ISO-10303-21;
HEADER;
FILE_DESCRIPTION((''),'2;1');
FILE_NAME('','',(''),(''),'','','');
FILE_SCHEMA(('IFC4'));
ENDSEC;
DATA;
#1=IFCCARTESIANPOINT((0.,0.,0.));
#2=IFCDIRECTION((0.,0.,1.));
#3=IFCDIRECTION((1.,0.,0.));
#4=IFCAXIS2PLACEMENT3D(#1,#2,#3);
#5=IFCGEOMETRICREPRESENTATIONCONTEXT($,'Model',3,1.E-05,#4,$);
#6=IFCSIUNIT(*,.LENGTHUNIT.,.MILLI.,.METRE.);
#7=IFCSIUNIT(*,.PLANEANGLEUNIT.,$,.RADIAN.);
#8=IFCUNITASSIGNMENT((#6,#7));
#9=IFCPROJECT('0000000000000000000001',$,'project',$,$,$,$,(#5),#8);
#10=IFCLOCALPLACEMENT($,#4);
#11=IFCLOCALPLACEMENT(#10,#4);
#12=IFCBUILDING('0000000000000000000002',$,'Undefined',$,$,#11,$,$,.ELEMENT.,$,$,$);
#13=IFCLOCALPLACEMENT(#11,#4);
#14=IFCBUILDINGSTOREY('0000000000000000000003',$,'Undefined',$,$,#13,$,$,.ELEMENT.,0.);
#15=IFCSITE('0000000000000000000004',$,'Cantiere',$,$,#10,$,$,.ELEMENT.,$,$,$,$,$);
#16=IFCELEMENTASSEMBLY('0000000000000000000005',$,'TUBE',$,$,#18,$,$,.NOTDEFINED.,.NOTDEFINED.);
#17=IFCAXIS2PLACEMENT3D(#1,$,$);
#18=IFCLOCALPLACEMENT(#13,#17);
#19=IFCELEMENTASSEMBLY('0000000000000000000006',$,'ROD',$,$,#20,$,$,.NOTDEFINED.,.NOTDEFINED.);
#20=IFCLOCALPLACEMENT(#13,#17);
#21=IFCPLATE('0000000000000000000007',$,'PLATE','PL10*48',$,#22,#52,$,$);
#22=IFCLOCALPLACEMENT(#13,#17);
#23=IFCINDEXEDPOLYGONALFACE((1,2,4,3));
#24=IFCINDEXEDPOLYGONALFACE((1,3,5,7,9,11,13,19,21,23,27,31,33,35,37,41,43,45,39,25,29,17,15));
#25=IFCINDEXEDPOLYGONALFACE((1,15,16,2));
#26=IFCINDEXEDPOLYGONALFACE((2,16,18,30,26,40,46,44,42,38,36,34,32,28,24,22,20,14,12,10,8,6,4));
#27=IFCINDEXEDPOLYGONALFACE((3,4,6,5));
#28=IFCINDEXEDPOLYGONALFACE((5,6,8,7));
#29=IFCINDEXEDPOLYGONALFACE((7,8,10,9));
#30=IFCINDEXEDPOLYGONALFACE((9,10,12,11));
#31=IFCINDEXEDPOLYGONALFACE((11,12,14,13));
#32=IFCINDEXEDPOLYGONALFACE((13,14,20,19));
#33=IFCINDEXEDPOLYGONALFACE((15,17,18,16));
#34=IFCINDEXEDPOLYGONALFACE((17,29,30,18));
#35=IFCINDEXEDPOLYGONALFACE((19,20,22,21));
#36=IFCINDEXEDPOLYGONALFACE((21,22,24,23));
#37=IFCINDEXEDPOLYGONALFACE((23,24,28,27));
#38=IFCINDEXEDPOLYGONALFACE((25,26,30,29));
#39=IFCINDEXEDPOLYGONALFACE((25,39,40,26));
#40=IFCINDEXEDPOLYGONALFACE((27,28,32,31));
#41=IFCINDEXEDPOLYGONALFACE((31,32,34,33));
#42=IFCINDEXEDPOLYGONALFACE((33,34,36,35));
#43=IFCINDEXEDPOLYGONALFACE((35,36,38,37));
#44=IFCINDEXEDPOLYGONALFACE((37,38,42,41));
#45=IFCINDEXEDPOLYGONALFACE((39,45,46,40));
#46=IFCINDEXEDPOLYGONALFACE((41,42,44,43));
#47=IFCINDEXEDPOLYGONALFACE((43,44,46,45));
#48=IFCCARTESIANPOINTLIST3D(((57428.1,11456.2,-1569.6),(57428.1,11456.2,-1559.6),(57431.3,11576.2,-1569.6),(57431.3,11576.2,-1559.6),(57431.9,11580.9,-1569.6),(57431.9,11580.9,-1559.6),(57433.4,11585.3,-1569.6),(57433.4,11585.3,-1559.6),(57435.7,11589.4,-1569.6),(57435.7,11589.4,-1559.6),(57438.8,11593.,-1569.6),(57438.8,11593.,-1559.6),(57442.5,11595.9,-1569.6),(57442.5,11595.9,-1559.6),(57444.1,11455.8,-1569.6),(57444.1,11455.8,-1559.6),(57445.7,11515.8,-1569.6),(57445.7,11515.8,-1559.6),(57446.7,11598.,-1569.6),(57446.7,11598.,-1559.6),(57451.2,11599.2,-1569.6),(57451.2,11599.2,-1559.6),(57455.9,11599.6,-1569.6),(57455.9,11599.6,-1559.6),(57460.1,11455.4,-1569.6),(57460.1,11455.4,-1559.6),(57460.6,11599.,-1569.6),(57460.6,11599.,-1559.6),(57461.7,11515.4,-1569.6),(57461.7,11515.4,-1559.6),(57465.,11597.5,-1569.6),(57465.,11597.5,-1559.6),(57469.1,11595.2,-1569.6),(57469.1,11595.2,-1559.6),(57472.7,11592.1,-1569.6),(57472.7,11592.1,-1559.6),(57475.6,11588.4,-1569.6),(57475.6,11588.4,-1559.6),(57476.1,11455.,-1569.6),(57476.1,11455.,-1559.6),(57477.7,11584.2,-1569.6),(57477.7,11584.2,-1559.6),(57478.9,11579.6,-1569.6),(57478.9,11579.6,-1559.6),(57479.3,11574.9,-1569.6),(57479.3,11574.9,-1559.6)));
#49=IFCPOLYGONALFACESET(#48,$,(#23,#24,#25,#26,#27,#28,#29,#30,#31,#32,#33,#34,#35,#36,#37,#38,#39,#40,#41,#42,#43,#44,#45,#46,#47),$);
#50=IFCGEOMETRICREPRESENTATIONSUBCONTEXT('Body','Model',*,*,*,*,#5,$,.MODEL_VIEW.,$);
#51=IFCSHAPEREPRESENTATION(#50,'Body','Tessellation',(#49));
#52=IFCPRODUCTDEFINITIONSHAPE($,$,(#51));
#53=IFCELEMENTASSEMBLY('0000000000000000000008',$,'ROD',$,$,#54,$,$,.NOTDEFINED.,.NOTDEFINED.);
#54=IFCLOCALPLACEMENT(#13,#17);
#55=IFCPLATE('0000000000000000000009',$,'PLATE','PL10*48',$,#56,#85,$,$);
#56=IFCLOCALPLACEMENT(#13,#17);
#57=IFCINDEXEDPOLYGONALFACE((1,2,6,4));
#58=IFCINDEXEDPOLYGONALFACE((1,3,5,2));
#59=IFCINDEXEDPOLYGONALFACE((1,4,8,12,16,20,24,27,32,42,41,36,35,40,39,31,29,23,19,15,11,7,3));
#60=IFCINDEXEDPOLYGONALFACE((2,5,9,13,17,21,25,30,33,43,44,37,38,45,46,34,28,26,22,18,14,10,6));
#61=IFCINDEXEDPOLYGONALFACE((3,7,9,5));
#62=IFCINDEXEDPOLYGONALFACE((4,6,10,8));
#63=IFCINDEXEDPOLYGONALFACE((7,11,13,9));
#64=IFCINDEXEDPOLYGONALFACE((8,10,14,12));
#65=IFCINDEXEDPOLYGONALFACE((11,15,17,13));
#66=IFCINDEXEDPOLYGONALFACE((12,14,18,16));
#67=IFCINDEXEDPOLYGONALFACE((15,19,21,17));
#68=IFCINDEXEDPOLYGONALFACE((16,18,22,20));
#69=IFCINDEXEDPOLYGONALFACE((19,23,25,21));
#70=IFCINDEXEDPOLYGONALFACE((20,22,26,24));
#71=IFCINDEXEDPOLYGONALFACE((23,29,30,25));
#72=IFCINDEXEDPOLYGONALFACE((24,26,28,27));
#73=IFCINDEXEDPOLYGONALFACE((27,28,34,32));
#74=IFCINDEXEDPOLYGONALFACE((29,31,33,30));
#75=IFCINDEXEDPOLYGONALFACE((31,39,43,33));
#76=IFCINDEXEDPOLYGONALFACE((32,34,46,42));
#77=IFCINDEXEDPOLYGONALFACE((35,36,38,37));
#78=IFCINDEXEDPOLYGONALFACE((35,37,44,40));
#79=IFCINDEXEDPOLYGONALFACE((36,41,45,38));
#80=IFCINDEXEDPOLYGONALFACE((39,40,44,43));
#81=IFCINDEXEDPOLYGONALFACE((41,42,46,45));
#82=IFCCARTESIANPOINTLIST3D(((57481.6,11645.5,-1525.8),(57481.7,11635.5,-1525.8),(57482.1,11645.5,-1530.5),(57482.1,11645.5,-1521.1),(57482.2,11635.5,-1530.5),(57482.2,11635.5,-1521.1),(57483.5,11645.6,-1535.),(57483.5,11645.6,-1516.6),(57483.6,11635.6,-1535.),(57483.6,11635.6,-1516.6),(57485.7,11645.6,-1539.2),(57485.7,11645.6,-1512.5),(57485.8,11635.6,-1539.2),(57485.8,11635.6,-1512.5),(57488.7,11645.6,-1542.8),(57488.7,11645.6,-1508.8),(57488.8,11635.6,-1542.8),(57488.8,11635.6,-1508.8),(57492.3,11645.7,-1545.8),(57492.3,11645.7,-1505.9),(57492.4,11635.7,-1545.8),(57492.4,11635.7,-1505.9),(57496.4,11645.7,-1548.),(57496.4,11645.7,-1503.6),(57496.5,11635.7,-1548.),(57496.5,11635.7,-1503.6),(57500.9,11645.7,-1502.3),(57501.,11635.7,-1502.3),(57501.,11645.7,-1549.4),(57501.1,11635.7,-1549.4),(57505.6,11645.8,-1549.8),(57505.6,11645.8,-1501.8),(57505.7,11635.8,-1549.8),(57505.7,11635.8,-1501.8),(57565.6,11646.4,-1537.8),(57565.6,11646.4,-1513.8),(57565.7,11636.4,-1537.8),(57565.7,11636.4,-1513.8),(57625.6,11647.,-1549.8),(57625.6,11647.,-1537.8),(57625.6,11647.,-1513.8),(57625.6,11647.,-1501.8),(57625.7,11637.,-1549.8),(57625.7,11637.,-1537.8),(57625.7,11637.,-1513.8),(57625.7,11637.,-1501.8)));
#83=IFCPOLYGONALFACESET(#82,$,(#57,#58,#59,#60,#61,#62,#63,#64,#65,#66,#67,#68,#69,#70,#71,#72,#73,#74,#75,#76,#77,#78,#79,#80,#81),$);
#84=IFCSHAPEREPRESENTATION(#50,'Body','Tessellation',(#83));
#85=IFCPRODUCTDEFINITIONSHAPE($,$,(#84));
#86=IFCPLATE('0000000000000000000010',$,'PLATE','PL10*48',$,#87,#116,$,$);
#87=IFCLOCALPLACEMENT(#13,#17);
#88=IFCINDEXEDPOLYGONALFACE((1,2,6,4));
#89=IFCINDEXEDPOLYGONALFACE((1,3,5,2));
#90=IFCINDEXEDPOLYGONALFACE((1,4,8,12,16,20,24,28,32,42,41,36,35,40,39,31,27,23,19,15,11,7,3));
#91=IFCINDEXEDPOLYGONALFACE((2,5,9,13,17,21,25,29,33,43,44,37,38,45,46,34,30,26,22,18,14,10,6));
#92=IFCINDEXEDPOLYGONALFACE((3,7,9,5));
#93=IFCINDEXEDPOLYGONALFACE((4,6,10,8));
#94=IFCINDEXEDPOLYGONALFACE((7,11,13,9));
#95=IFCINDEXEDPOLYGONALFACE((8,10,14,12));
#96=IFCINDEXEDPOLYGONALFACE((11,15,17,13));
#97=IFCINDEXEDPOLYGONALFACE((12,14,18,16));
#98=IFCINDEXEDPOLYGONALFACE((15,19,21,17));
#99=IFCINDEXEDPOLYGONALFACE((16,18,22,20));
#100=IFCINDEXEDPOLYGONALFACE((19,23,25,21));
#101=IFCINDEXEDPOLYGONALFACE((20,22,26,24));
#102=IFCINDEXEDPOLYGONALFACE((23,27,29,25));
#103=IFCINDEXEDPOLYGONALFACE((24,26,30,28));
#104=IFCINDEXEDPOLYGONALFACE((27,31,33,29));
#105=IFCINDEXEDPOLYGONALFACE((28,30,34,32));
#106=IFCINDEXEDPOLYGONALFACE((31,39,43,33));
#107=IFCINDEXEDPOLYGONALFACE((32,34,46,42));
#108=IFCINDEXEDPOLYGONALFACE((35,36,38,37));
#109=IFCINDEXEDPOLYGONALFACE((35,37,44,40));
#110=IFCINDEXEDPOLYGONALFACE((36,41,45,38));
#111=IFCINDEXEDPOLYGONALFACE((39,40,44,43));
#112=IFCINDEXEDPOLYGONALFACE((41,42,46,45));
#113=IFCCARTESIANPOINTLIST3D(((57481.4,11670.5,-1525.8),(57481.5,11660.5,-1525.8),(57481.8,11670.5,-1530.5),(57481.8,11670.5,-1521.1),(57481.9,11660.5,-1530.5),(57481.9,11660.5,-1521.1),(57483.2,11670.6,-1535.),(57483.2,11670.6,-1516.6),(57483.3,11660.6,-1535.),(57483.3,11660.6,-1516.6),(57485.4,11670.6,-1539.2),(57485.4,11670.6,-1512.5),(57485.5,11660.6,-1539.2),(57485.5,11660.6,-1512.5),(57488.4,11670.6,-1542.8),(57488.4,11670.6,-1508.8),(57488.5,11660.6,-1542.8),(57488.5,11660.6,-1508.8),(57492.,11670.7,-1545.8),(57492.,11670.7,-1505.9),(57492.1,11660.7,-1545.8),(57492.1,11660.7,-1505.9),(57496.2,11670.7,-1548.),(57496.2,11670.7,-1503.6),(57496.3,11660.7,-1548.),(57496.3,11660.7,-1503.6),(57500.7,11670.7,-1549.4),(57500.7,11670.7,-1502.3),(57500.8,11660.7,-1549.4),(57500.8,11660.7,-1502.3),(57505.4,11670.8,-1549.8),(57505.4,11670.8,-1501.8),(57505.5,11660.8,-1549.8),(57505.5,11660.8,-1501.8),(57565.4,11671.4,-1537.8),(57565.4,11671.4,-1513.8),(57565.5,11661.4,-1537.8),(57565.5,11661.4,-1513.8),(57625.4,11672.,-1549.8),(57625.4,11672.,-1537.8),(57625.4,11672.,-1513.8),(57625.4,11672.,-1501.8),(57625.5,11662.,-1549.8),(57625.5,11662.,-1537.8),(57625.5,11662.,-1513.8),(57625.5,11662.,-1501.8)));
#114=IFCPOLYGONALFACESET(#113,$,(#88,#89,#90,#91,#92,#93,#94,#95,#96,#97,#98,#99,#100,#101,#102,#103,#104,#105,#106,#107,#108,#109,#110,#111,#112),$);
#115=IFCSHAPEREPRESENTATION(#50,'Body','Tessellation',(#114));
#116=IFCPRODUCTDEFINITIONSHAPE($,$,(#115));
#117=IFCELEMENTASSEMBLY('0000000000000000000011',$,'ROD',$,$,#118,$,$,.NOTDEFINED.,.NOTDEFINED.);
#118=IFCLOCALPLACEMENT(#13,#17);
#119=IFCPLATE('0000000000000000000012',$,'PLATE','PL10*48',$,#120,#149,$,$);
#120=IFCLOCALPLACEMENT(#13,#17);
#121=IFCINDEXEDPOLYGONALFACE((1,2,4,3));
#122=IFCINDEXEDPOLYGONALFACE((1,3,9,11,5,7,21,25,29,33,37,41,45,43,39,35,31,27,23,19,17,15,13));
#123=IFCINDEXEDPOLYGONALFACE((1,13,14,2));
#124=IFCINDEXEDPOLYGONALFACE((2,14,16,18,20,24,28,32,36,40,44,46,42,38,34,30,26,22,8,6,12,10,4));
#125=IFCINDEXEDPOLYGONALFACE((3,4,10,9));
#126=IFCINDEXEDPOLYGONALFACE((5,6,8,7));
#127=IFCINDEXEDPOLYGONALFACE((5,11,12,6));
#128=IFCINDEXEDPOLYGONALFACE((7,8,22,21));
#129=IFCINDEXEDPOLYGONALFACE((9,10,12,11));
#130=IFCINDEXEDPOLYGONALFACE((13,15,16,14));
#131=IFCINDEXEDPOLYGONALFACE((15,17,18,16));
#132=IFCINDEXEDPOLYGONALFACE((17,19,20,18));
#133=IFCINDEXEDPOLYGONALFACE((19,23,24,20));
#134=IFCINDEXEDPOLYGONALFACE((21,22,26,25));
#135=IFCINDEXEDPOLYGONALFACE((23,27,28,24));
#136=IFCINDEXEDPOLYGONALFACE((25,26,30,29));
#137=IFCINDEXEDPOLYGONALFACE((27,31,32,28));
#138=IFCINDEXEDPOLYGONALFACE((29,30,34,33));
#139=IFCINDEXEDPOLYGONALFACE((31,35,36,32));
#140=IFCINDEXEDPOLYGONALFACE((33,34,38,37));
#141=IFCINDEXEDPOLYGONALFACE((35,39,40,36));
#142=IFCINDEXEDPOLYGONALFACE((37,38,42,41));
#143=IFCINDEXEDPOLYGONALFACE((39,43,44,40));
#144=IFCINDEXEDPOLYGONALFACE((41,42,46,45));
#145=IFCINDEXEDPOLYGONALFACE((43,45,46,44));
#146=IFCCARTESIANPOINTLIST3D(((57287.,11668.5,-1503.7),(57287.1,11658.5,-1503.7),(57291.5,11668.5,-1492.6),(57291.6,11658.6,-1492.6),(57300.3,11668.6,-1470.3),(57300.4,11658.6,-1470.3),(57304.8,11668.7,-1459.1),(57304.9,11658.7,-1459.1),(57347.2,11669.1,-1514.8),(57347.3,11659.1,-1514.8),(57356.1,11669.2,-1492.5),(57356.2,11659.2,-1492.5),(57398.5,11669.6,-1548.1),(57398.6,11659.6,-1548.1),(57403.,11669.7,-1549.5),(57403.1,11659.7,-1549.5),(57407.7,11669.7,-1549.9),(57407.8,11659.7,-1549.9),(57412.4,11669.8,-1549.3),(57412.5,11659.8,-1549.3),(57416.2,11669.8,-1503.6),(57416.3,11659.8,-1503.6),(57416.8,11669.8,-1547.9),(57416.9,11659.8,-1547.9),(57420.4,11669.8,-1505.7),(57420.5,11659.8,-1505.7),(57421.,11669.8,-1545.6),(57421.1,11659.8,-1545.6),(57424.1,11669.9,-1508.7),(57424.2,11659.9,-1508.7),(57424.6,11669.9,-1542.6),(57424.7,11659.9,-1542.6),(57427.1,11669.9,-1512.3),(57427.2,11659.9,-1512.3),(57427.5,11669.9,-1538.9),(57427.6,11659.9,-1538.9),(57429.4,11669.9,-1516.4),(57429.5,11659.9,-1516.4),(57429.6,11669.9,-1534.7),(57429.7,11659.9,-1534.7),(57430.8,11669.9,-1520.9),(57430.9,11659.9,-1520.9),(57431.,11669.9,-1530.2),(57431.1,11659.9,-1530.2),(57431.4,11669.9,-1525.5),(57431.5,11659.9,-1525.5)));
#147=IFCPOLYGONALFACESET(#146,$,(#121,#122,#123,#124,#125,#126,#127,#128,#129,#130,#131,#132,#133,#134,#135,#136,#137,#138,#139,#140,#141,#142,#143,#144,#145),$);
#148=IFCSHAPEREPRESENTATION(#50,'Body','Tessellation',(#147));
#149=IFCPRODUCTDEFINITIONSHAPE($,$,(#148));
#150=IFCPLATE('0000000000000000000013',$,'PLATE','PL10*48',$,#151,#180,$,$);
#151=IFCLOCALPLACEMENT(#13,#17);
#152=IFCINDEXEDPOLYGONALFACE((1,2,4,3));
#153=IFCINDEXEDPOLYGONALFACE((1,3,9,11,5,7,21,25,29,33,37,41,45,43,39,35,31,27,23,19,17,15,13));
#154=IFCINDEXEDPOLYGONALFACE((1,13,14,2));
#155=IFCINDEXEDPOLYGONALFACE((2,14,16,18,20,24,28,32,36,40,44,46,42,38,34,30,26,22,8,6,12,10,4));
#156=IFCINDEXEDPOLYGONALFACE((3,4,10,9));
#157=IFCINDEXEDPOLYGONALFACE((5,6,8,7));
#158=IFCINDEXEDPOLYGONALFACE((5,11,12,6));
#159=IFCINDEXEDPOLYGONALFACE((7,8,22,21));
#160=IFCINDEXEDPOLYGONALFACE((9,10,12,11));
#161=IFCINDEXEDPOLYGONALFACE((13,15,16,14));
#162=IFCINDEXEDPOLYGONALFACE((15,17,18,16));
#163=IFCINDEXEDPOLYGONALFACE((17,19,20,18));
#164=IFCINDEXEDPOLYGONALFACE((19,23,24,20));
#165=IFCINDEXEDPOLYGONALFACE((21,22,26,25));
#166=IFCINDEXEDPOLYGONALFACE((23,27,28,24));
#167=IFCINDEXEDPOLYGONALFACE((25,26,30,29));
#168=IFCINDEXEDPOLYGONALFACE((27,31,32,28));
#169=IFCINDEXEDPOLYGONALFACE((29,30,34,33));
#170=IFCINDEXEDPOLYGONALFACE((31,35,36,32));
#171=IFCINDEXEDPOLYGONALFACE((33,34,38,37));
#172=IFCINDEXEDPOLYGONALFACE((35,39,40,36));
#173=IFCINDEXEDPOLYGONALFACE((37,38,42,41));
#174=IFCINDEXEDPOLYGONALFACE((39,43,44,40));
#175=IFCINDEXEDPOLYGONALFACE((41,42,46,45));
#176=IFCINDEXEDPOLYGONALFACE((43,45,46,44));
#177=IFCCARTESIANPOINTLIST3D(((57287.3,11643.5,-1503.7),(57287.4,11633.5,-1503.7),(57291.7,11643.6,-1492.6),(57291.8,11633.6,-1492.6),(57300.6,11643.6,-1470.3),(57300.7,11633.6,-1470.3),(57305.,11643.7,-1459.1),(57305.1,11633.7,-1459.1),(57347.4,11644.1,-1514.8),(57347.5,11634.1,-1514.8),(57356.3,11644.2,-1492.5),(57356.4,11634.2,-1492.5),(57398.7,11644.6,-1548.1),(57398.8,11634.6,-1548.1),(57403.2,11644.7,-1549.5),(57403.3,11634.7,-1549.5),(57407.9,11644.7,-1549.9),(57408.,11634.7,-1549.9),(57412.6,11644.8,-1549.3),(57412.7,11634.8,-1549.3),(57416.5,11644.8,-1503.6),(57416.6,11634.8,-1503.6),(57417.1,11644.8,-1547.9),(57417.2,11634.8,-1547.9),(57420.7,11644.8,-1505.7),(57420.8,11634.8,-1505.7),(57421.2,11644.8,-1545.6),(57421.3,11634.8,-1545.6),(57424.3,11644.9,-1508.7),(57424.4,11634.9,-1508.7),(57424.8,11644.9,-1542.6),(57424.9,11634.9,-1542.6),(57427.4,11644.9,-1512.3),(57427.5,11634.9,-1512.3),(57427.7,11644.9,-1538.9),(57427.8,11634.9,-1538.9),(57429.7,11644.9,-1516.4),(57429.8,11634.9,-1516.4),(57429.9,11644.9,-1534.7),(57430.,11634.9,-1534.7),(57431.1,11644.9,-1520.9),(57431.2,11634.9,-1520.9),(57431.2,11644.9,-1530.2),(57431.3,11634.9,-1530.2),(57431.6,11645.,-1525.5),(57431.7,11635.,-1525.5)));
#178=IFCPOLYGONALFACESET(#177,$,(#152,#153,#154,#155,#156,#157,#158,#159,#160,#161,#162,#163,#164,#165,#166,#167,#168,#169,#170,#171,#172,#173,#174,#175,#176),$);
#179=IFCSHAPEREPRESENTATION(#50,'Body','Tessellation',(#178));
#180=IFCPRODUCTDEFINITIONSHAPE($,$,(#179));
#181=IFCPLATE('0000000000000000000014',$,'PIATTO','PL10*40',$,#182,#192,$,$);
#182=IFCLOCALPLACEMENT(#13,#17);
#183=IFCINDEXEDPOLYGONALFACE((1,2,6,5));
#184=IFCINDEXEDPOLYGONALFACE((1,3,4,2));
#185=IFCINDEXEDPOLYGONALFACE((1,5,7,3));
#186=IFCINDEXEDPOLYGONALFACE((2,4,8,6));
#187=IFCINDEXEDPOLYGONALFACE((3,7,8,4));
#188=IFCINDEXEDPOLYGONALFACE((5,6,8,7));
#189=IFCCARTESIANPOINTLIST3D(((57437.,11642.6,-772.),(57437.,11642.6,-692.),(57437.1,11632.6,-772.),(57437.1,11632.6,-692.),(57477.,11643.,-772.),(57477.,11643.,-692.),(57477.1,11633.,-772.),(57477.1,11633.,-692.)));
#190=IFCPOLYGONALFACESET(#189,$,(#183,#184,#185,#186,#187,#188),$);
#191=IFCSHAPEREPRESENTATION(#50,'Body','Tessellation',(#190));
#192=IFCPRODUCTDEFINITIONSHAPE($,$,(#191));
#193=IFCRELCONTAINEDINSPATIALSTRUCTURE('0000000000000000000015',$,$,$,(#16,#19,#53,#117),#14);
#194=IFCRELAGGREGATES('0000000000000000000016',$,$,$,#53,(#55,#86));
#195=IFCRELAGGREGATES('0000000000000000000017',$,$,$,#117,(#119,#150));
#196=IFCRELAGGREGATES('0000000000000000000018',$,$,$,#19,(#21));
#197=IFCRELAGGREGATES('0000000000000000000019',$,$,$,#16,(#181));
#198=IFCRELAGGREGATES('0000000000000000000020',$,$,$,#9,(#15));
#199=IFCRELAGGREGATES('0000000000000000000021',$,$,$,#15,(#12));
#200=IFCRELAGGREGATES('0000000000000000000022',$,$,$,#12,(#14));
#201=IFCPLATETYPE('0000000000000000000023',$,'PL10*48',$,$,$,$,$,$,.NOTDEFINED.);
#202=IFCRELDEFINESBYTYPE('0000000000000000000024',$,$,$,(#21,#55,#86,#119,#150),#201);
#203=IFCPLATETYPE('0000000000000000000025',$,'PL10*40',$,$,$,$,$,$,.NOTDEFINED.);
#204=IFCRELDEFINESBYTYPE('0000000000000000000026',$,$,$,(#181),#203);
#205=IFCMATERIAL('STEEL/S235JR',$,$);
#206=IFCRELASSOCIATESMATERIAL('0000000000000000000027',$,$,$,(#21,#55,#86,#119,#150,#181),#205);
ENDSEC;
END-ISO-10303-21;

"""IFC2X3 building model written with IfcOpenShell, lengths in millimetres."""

from ifc_helpers import new_model, si_unit, frame, origin_with_axes, place, context, subcontext, project, spatial, polyline, outline, extrude, material, type_object, element, aggregate, save


model = new_model("IFC2X3")

# Units and contexts
model_context = context("Model", 3, precision=1e-05, world=origin_with_axes())
body_context = subcontext(model_context, "Body", "Model", "MODEL_VIEW")
ifc_project = project(units=[si_unit("LENGTHUNIT", "METRE", prefix="MILLI"), si_unit("PLANEANGLEUNIT", "RADIAN")], contexts=[model_context])

# Site, building, storey
site_placement = place(None, origin_with_axes())
site = spatial("IfcSite", under=ifc_project, at=site_placement, Name="Cantiere", CompositionType="ELEMENT")
building_placement = place(site_placement, origin_with_axes())
building = spatial("IfcBuilding", under=site, at=building_placement, Name="Undefined", CompositionType="ELEMENT")
storey_placement = place(building_placement, origin_with_axes())
storey = spatial("IfcBuildingStorey", under=building, at=storey_placement, Name="Undefined", CompositionType="ELEMENT", Elevation=0.0)

# Element assembly
assembly_1_placement = place(storey_placement, origin_with_axes())
assembly_1 = element("IfcElementAssembly", 1, at=assembly_1_placement, inside=storey, Name="TUBE", AssemblyPlace="NOTDEFINED", PredefinedType="NOTDEFINED")
ifc_material_1 = material(Name="STEEL/S235JR")

# Element assemblies, plates
assembly_2_placement = place(storey_placement, origin_with_axes())
assembly_2 = element("IfcElementAssembly", 2, at=assembly_2_placement, inside=storey, Name="ROD", AssemblyPlace="NOTDEFINED", PredefinedType="NOTDEFINED")
plate_type_1 = type_object("IfcPlateType", Name="PL10*48", PredefinedType="NOTDEFINED")
plate_1_placement = place(assembly_2_placement, frame((57476.1, 11455.0, -1564.6), z_axis=(0.0, 0.0, 1.0), x_axis=(0.026238, 0.999656, 0.0)))
plate_1 = element("IfcPlate", 3, at=plate_1_placement, type_object=plate_type_1, material=ifc_material_1, Name="PLATE", Description="PL10*48", context=body_context, shape_type="SweptSolid", body=[
    extrude(outline(polyline([(0.0, 0.0), (120.0, 0.0), (124.7, 0.5), (129.2, 1.8), (133.3, 4.0), (137.0, 7.0), (140.0, 10.7), (142.2, 14.8), (143.5, 19.3), (144.0, 24.0), (144.0, 24.0), (143.5, 28.7), (142.2, 33.2), (140.0, 37.3), (137.0, 41.0), (133.3, 44.0), (129.2, 46.2), (124.7, 47.5), (120.0, 48.0), (0.0, 48.0), (0.0, 32.0), (60.0, 32.0), (60.0, 16.0), (0.0, 16.0), (0.0, 0.0)])), frame((0.0, 0.0, -5.0), z_axis=(0.0, 0.0, 1.0), x_axis=(1.0, 0.0, 0.0)), (0.0, 0.0, 1.0), 10.0),
])
assembly_3_placement = place(storey_placement, origin_with_axes())
assembly_3 = element("IfcElementAssembly", 4, at=assembly_3_placement, inside=storey, Name="ROD", AssemblyPlace="NOTDEFINED", PredefinedType="NOTDEFINED")
plate_2_placement = place(assembly_3_placement, frame((57625.7, 11642.0, -1549.8), z_axis=(-0.01014, 0.999949, 0.0), x_axis=(-0.999949, -0.01014, -0.000205)))
plate_2 = element("IfcPlate", 5, at=plate_2_placement, type_object=plate_type_1, material=ifc_material_1, Name="PLATE", Description="PL10*48", context=body_context, shape_type="SweptSolid", body=[
    extrude(outline(polyline([(0.0, 0.0), (120.0, 0.0), (124.7, 0.5), (129.2, 1.8), (133.3, 4.0), (137.0, 7.0), (140.0, 10.7), (142.2, 14.8), (143.5, 19.3), (144.0, 24.0), (144.0, 24.0), (143.5, 28.7), (142.2, 33.2), (140.0, 37.3), (137.0, 41.0), (133.3, 44.0), (129.2, 46.2), (124.7, 47.5), (120.0, 48.0), (0.0, 48.0), (0.0, 36.0), (60.0, 36.0), (60.0, 12.0), (0.0, 12.0), (0.0, 0.0)])), frame((0.0, 0.0, -5.0), z_axis=(0.0, 0.0, 1.0), x_axis=(1.0, 0.0, 0.0)), (0.0, 0.0, 1.0), 10.0),
])
plate_3_placement = place(assembly_3_placement, frame((57625.4, 11667.0, -1549.8), z_axis=(-0.01014, 0.999949, 0.0), x_axis=(-0.999949, -0.01014, -0.000205)))
plate_3 = element("IfcPlate", 6, at=plate_3_placement, type_object=plate_type_1, material=ifc_material_1, Name="PLATE", Description="PL10*48", context=body_context, shape_type="SweptSolid", body=[
    extrude(outline(polyline([(0.0, 0.0), (120.0, 0.0), (124.7, 0.5), (129.2, 1.8), (133.3, 4.0), (137.0, 7.0), (140.0, 10.7), (142.2, 14.8), (143.5, 19.3), (144.0, 24.0), (144.0, 24.0), (143.5, 28.7), (142.2, 33.2), (140.0, 37.3), (137.0, 41.0), (133.3, 44.0), (129.2, 46.2), (124.7, 47.5), (120.0, 48.0), (0.0, 48.0), (0.0, 36.0), (60.0, 36.0), (60.0, 12.0), (0.0, 12.0), (0.0, 0.0)])), frame((0.0, 0.0, -5.0), z_axis=(0.0, 0.0, 1.0), x_axis=(1.0, 0.0, 0.0)), (0.0, 0.0, 1.0), 10.0),
])
aggregate(assembly_3, [plate_2, plate_3])
assembly_4_placement = place(storey_placement, origin_with_axes())
assembly_4 = element("IfcElementAssembly", 7, at=assembly_4_placement, inside=storey, Name="ROD", AssemblyPlace="NOTDEFINED", PredefinedType="NOTDEFINED")
plate_4_placement = place(assembly_4_placement, frame((57304.8, 11663.7, -1459.1), z_axis=(-0.009999, 0.99995, 0.0), x_axis=(0.928849, 0.009288, -0.370341)))
plate_4 = element("IfcPlate", 8, at=plate_4_placement, type_object=plate_type_1, material=ifc_material_1, Name="PLATE", Description="PL10*48", context=body_context, shape_type="SweptSolid", body=[
    extrude(outline(polyline([(0.0, 0.0), (120.0, 0.0), (124.7, 0.5), (129.2, 1.8), (133.3, 4.0), (137.0, 7.0), (140.0, 10.7), (142.2, 14.8), (143.5, 19.3), (144.0, 24.0), (144.0, 24.0), (143.5, 28.7), (142.2, 33.2), (140.0, 37.3), (137.0, 41.0), (133.3, 44.0), (129.2, 46.2), (124.7, 47.5), (120.0, 48.0), (0.0, 48.0), (0.0, 36.0), (60.0, 36.0), (60.0, 12.0), (0.0, 12.0), (0.0, 0.0)])), frame((0.0, 0.0, -5.0), z_axis=(0.0, 0.0, 1.0), x_axis=(1.0, 0.0, 0.0)), (0.0, 0.0, 1.0), 10.0),
])
plate_5_placement = place(assembly_4_placement, frame((57305.1, 11638.7, -1459.1), z_axis=(-0.009999, 0.99995, 0.0), x_axis=(0.928849, 0.009288, -0.370341)))
plate_5 = element("IfcPlate", 9, at=plate_5_placement, type_object=plate_type_1, material=ifc_material_1, Name="PLATE", Description="PL10*48", context=body_context, shape_type="SweptSolid", body=[
    extrude(outline(polyline([(0.0, 0.0), (120.0, 0.0), (124.7, 0.5), (129.2, 1.8), (133.3, 4.0), (137.0, 7.0), (140.0, 10.7), (142.2, 14.8), (143.5, 19.3), (144.0, 24.0), (144.0, 24.0), (143.5, 28.7), (142.2, 33.2), (140.0, 37.3), (137.0, 41.0), (133.3, 44.0), (129.2, 46.2), (124.7, 47.5), (120.0, 48.0), (0.0, 48.0), (0.0, 36.0), (60.0, 36.0), (60.0, 12.0), (0.0, 12.0), (0.0, 0.0)])), frame((0.0, 0.0, -5.0), z_axis=(0.0, 0.0, 1.0), x_axis=(1.0, 0.0, 0.0)), (0.0, 0.0, 1.0), 10.0),
])
aggregate(assembly_4, [plate_4, plate_5])

# Plate
plate_type_2 = type_object("IfcPlateType", Name="PL10*40", PredefinedType="NOTDEFINED")
plate_6_placement = place(assembly_1_placement, frame((57477.1, 11638.0, -772.0), z_axis=(0.01014, -0.999949, 0.0), x_axis=(0.0, 0.0, 1.0)))
plate_6 = element("IfcPlate", 10, at=plate_6_placement, type_object=plate_type_2, material=ifc_material_1, Name="PIATTO", Description="PL10*40", context=body_context, shape_type="SweptSolid", body=[
    extrude(outline(polyline([(0.0, 0.0), (80.0, 0.0), (80.0, 40.0), (0.0, 40.0), (0.0, 0.0)])), frame((0.0, 0.0, -5.0), z_axis=(0.0, 0.0, 1.0), x_axis=(1.0, 0.0, 0.0)), (0.0, 0.0, 1.0), 10.0),
])

aggregate(assembly_2, [plate_1])
aggregate(assembly_1, [plate_6])

save(model, "model.ifc")
